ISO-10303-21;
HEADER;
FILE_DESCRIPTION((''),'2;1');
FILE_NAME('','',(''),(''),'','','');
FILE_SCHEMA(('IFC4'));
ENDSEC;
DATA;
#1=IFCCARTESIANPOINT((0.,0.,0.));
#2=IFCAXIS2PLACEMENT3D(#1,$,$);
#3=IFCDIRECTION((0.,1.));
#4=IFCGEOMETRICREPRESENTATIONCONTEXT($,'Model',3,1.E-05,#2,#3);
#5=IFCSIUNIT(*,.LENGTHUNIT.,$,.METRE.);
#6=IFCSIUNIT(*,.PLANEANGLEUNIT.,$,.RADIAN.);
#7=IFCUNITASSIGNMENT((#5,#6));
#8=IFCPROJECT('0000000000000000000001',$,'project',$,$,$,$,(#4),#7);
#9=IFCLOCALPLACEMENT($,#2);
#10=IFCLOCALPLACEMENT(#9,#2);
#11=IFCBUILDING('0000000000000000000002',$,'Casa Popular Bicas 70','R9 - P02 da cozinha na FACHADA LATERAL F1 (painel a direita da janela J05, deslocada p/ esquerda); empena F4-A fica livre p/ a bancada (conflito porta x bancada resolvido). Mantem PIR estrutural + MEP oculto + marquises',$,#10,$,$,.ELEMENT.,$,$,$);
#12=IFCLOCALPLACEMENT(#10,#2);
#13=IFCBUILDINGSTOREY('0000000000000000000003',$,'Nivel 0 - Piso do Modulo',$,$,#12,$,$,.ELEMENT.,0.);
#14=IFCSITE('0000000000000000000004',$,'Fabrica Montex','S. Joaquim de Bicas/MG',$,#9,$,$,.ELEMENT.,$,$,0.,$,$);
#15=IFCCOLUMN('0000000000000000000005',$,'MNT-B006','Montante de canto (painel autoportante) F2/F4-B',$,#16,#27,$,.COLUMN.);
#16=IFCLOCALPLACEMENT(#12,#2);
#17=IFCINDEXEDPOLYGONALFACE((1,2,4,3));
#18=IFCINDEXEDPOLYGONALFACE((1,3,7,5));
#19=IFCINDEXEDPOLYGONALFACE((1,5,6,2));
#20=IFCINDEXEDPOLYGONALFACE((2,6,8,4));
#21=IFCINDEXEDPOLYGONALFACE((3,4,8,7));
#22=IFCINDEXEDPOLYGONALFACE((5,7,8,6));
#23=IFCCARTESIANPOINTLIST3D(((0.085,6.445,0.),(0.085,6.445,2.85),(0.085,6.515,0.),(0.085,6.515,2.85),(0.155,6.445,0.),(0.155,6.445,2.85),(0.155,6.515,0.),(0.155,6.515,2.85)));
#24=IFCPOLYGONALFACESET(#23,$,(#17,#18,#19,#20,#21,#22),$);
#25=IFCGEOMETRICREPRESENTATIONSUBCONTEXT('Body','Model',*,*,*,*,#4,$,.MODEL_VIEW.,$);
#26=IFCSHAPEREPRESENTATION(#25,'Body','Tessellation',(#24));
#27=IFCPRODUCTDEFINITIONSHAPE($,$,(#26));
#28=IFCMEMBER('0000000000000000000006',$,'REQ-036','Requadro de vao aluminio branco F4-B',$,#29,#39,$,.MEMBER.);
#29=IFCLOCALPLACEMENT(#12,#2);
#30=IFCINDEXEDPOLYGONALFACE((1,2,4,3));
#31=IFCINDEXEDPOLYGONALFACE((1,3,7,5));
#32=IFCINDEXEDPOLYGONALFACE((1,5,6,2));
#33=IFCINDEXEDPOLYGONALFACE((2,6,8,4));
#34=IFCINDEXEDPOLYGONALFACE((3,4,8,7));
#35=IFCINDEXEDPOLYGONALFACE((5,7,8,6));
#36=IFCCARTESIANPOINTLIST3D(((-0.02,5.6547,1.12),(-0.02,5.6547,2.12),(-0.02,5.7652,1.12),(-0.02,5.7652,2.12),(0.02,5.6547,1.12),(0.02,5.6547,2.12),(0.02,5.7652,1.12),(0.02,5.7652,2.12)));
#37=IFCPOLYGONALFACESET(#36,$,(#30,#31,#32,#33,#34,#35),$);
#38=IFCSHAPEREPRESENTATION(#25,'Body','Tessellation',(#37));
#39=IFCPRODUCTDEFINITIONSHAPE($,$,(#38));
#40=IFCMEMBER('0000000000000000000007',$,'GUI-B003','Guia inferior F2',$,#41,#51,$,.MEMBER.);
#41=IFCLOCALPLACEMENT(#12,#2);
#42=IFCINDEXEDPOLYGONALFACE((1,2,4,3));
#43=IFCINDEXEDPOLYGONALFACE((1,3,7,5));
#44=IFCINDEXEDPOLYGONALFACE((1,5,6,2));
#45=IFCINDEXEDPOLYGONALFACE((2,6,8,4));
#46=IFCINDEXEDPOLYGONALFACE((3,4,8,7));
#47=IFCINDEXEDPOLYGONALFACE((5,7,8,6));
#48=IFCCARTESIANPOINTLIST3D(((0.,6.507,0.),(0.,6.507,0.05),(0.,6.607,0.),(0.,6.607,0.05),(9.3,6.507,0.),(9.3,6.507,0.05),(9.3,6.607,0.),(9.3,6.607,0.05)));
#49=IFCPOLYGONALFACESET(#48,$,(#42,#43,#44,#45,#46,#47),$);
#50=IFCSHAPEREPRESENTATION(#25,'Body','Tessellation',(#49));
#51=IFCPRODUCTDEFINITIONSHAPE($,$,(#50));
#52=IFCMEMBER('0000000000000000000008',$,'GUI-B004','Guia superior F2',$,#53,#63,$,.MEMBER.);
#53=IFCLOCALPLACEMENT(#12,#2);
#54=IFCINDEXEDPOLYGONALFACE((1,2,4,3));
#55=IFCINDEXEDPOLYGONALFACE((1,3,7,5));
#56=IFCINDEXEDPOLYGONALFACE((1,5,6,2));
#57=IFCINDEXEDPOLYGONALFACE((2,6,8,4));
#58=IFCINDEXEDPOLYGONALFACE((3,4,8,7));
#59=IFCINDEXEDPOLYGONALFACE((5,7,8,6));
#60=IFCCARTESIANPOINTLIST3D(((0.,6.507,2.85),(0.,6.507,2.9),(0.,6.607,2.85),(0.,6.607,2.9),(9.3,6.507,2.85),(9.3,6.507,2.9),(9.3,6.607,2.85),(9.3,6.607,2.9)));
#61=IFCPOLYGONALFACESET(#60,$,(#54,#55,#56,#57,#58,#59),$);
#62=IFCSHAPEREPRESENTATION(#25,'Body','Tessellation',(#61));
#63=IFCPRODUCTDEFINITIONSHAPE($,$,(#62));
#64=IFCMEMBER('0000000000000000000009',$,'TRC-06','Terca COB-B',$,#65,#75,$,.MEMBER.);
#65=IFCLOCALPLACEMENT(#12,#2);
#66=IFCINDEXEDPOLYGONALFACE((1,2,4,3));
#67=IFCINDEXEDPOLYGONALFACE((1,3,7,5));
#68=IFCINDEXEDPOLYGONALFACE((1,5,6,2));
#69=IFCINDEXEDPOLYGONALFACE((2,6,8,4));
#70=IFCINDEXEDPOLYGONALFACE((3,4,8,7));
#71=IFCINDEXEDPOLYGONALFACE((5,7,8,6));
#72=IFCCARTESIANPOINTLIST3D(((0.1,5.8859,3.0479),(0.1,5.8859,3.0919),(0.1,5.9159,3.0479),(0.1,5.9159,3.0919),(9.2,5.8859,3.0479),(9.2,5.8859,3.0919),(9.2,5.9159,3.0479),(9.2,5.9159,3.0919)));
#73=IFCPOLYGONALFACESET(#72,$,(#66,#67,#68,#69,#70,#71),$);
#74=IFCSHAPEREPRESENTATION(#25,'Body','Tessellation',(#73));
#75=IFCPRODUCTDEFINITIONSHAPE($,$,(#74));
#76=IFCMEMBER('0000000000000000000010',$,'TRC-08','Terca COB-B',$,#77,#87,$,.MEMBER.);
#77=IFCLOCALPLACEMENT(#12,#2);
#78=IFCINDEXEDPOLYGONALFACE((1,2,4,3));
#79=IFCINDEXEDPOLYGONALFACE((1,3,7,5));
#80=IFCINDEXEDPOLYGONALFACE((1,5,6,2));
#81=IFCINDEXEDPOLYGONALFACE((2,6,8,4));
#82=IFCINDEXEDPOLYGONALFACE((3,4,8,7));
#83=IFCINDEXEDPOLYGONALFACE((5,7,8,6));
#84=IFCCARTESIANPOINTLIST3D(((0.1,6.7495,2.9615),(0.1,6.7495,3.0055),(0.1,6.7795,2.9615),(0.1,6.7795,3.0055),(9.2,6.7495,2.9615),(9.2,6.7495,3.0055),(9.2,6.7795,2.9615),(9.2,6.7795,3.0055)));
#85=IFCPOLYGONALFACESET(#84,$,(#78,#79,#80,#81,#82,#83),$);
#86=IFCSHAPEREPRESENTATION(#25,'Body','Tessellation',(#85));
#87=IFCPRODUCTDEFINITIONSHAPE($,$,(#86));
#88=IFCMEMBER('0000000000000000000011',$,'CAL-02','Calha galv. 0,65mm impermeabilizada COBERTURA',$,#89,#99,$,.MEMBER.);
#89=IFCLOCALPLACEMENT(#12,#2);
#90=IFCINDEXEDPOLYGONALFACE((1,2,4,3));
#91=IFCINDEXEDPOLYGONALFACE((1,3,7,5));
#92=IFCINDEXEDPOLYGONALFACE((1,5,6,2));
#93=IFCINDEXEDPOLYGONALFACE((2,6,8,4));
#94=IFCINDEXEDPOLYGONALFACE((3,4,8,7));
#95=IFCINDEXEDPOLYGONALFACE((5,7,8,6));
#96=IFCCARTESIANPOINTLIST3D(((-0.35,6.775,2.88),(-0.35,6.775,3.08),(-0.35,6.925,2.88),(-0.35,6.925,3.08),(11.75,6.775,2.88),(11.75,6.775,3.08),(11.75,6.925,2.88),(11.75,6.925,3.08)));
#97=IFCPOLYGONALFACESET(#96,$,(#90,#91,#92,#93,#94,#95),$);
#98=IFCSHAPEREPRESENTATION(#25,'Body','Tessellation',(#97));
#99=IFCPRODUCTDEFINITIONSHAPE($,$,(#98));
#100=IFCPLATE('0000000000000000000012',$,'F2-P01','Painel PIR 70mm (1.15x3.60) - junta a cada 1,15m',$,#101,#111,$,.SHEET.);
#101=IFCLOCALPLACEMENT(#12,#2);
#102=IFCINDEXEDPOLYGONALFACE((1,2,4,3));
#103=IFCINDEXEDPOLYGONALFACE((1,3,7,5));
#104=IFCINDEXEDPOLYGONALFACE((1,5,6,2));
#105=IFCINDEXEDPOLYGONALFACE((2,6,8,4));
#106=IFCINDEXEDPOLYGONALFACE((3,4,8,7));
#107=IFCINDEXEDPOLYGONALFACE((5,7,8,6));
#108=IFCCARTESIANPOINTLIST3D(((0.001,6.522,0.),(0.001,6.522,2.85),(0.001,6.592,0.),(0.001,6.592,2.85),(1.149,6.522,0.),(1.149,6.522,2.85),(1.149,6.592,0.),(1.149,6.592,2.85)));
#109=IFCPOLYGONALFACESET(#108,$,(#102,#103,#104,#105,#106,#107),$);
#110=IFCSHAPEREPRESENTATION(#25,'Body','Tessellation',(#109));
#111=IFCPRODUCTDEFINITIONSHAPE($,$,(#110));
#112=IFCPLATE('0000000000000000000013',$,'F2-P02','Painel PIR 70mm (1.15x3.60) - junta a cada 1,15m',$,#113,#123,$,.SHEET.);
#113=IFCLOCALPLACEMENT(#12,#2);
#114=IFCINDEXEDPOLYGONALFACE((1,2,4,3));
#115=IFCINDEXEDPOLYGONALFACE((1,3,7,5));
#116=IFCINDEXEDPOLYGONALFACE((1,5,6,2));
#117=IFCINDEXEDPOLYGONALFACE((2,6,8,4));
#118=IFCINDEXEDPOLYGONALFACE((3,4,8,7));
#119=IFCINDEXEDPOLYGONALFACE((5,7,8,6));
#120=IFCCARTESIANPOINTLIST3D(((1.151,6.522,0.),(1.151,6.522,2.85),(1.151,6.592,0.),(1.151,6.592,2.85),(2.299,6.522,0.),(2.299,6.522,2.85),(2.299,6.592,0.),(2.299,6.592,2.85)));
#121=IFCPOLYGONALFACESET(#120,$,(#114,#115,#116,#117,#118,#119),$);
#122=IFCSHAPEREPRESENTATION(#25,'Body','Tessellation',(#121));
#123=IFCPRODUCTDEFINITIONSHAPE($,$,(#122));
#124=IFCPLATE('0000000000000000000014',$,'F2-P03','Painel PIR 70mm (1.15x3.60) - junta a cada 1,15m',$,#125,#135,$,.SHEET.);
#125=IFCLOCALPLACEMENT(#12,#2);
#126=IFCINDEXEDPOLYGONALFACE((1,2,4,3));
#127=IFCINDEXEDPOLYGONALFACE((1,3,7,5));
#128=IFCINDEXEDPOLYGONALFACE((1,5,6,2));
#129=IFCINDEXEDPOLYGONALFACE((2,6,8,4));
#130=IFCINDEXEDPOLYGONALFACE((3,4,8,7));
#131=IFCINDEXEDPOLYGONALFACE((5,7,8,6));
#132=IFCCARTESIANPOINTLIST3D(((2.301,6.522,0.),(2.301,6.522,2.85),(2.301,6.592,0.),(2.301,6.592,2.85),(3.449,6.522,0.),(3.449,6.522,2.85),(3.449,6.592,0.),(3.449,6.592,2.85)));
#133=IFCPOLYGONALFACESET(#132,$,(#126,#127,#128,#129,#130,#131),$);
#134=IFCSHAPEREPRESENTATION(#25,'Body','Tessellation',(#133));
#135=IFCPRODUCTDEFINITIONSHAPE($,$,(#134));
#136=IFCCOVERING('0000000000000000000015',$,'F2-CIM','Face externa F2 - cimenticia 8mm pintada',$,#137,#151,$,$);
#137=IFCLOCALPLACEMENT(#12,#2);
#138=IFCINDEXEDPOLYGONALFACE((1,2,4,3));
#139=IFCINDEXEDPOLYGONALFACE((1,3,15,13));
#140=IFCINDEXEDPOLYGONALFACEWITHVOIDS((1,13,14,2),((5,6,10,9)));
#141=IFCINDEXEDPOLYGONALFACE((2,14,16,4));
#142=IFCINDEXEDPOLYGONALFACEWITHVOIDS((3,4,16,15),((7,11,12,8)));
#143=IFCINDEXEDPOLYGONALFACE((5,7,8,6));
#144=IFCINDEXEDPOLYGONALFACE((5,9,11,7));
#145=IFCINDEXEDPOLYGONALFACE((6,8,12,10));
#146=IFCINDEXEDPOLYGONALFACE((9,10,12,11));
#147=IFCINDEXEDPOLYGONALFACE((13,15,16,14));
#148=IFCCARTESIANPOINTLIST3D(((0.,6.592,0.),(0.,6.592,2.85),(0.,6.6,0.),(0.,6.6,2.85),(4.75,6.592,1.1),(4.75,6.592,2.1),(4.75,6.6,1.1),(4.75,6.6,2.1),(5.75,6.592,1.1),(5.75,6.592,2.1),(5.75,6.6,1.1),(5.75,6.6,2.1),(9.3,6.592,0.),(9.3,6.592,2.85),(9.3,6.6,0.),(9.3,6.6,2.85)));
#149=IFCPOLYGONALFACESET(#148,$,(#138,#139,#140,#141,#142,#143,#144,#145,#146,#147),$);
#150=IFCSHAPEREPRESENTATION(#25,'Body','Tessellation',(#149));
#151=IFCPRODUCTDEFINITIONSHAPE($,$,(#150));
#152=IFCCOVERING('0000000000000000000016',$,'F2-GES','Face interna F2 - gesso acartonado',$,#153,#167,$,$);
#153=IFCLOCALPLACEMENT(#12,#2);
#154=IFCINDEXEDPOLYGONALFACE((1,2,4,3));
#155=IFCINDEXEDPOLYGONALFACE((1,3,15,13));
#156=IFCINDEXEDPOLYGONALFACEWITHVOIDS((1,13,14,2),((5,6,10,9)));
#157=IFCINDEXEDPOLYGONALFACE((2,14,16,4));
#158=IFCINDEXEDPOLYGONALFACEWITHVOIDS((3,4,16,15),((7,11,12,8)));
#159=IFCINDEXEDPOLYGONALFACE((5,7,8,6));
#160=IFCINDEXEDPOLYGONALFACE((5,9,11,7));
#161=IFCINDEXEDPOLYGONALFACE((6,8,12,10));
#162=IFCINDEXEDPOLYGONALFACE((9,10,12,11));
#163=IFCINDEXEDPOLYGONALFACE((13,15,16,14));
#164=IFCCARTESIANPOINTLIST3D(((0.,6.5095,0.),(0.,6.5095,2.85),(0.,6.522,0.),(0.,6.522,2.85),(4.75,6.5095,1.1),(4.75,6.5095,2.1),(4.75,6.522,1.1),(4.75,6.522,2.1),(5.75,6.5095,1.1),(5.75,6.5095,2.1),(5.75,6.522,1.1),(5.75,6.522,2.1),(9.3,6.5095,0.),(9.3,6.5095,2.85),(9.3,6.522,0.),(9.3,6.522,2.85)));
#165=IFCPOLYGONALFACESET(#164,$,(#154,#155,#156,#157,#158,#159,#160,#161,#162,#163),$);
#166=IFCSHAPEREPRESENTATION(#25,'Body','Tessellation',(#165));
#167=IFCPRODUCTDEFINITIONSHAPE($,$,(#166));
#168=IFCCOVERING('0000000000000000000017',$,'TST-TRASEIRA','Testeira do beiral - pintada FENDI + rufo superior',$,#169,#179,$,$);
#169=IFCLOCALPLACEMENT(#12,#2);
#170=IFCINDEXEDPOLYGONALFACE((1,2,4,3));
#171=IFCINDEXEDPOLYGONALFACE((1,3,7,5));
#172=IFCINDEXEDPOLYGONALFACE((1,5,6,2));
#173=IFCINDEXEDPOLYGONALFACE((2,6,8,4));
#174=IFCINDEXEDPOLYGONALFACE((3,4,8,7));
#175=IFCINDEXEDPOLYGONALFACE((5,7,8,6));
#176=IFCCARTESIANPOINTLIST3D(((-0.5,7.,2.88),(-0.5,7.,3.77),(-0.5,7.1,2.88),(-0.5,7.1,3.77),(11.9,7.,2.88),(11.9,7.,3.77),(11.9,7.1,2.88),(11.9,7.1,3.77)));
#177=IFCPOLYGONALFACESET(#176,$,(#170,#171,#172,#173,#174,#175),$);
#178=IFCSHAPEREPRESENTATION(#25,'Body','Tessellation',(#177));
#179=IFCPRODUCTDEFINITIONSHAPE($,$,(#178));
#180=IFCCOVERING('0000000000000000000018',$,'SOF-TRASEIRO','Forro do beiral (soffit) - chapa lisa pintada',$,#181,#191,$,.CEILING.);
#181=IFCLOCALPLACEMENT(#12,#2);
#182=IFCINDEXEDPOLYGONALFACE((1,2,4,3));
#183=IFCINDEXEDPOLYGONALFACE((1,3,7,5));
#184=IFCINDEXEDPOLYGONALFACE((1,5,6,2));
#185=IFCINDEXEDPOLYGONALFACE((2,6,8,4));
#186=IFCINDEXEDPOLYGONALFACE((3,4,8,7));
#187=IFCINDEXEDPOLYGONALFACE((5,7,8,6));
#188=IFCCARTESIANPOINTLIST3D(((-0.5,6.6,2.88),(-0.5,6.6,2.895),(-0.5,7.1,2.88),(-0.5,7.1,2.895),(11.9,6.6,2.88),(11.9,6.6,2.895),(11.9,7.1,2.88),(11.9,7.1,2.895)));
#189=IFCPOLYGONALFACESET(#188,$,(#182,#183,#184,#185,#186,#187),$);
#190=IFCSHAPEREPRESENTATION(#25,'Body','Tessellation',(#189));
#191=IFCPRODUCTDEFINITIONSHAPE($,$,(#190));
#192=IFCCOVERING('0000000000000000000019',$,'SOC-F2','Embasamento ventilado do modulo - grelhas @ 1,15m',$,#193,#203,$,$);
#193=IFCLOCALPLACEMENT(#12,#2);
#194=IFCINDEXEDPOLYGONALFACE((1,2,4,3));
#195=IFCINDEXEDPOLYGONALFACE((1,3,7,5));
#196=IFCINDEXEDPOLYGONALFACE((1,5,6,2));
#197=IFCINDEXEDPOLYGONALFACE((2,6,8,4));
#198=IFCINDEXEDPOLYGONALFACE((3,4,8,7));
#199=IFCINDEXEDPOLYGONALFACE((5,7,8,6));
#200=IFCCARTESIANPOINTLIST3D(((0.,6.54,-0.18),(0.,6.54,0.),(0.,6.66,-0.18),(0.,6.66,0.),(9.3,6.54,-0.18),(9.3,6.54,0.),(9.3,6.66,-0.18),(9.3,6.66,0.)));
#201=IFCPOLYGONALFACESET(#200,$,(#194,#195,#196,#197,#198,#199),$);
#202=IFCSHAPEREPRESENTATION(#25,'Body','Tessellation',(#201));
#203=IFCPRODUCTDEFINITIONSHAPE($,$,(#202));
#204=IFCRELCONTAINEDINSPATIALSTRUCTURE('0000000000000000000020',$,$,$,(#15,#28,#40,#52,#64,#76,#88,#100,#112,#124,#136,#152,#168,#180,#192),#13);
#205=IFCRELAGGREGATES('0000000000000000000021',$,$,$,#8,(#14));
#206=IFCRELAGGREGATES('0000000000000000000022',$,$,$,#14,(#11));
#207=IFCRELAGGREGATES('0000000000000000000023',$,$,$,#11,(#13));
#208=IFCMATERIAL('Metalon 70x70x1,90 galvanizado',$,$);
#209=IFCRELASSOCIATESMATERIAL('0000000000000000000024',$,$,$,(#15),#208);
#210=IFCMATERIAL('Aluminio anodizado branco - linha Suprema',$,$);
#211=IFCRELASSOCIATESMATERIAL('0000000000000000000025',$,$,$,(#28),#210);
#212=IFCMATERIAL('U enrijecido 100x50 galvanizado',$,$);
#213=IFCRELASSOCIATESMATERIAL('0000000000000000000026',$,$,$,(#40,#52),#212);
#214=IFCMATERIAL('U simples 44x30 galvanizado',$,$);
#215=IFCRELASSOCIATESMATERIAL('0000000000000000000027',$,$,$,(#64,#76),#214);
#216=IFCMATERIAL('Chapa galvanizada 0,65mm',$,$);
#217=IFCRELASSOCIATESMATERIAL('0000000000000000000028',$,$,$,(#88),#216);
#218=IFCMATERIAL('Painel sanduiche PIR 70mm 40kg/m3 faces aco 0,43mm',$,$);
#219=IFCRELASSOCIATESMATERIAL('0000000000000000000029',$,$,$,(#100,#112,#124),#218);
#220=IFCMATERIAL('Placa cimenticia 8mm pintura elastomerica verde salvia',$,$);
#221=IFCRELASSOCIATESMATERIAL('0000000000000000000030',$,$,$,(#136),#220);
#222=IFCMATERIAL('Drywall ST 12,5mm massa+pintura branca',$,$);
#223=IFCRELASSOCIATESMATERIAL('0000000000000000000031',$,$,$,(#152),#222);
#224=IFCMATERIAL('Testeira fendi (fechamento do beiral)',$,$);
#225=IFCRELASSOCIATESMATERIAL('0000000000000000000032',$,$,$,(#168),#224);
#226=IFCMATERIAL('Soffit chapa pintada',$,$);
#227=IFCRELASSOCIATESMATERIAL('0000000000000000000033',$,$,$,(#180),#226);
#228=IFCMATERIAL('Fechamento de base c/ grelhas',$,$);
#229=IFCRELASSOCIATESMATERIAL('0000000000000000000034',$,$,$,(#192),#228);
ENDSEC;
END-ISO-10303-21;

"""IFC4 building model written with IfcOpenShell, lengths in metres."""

from ifc_helpers import new_model, si_unit, direction, frame, frame_2d, origin, origin_2d, place, context, subcontext, project, spatial, rectangle, extrude, material, element, save


model = new_model("IFC4")

# Units and contexts
model_context = context("Model", 3, precision=1e-05, world=origin(), true_north=direction((0.0, 1.0)))
body_context = subcontext(model_context, "Body", "Model", "MODEL_VIEW")
ifc_project = project(units=[si_unit("LENGTHUNIT", "METRE"), si_unit("PLANEANGLEUNIT", "RADIAN")], contexts=[model_context])

# Site, building, storey
site_placement = place(None, origin())
site = spatial("IfcSite", under=ifc_project, at=site_placement, Name="Fabrica Montex", Description="S. Joaquim de Bicas/MG", CompositionType="ELEMENT", RefElevation=0.0)
building_placement = place(site_placement, origin())
building = spatial("IfcBuilding", under=site, at=building_placement, Name="Casa Popular Bicas 70", Description="R9 - P02 da cozinha na FACHADA LATERAL F1 (painel a direita da janela J05, deslocada p/ esquerda); empena F4-A fica livre p/ a bancada (conflito porta x bancada resolvido). Mantem PIR estrutural + MEP oculto + marquises", CompositionType="ELEMENT")
storey_placement = place(building_placement, origin())
storey = spatial("IfcBuildingStorey", under=building, at=storey_placement, Name="Nivel 0 - Piso do Modulo", CompositionType="ELEMENT", Elevation=0.0)

# Column
ifc_material_1 = material(Name="Metalon 70x70x1,90 galvanizado")
column_placement = place(storey_placement, frame((0.12, 6.48, 0.0)))
element("IfcColumn", 1, at=column_placement, inside=storey, material=ifc_material_1, Name="MNT-B006", Description="Montante de canto (painel autoportante) F2/F4-B", PredefinedType="COLUMN", context=body_context, shape_type="SweptSolid", body=[
    extrude(rectangle(XDim=0.07, YDim=0.07, at=origin_2d()), origin(), (0.0, 0.0, 1.0), 2.85),
])

# Members
ifc_material_2 = material(Name="Aluminio anodizado branco - linha Suprema")
member_1_placement = place(storey_placement, frame((0.0, 5.71, 1.12), z_axis=(0.0, 0.0, 1.0), x_axis=(1.0, 0.0, 0.0)))
element("IfcMember", 2, at=member_1_placement, inside=storey, material=ifc_material_2, Name="REQ-036", Description="Requadro de vao aluminio branco F4-B", PredefinedType="MEMBER", context=body_context, shape_type="SweptSolid", body=[
    extrude(rectangle(XDim=0.04, YDim=0.1105, at=origin_2d()), origin(), (0.0, 0.0, 1.0), 1.0),
])
ifc_material_3 = material(Name="U enrijecido 100x50 galvanizado")
for number, where, z_axis, x_axis, name, description in (
    (3, (0.0, 6.557, 0.025), (1.0, 0.0, 0.0), (0.0, 0.0, 1.0), "GUI-B003", "Guia inferior F2"),
    (4, (0.0, 6.557, 2.875), (1.0, 0.0, 0.0), (0.0, 0.0, 1.0), "GUI-B004", "Guia superior F2"),
):
    element("IfcMember", number, at=place(storey_placement, frame(where, z_axis=z_axis, x_axis=x_axis)), inside=storey, material=ifc_material_3, Name=name, Description=description, PredefinedType="MEMBER", context=body_context, shape_type="SweptSolid", body=[
        extrude(rectangle(XDim=0.05, YDim=0.1, at=origin_2d()), origin(), (0.0, 0.0, 1.0), 9.3),
    ])
ifc_material_4 = material(Name="U simples 44x30 galvanizado")
for number, where, z_axis, x_axis, name in (
    (5, (0.1, 5.9009, 3.0699), (1.0, 0.0, 0.0), (0.0, 0.0, 1.0), "TRC-06"),
    (6, (0.1, 6.7645, 2.9835), (1.0, 0.0, 0.0), (0.0, 0.0, 1.0), "TRC-08"),
):
    element("IfcMember", number, at=place(storey_placement, frame(where, z_axis=z_axis, x_axis=x_axis)), inside=storey, material=ifc_material_4, Name=name, Description="Terca COB-B", PredefinedType="MEMBER", context=body_context, shape_type="SweptSolid", body=[
        extrude(rectangle(XDim=0.044, YDim=0.03, at=origin_2d()), origin(), (0.0, 0.0, 1.0), 9.1),
    ])
ifc_material_5 = material(Name="Chapa galvanizada 0,65mm")
member_2_placement = place(storey_placement, frame((-0.35, 6.85, 2.98), z_axis=(1.0, 0.0, 0.0), x_axis=(0.0, 0.0, 1.0)))
element("IfcMember", 7, at=member_2_placement, inside=storey, material=ifc_material_5, Name="CAL-02", Description="Calha galv. 0,65mm impermeabilizada COBERTURA", PredefinedType="MEMBER", context=body_context, shape_type="SweptSolid", body=[
    extrude(rectangle(XDim=0.2, YDim=0.15, at=origin_2d()), origin(), (0.0, 0.0, 1.0), 12.1),
])

# Plates
ifc_material_6 = material(Name="Painel sanduiche PIR 70mm 40kg/m3 faces aco 0,43mm")
for number, where, x_axis, name in (
    (8, (0.001, 6.557, 0.0), (1.0, 0.0, 0.0), "F2-P01"),
    (9, (1.151, 6.557, 0.0), (1.0, 0.0, 0.0), "F2-P02"),
    (10, (2.301, 6.557, 0.0), (1.0, 0.0, 0.0), "F2-P03"),
):
    element("IfcPlate", number, at=place(storey_placement, frame(where, x_axis=x_axis)), inside=storey, material=ifc_material_6, Name=name, Description="Painel PIR 70mm (1.15x3.60) - junta a cada 1,15m", PredefinedType="SHEET", context=body_context, shape_type="SweptSolid", body=[
        extrude(rectangle(XDim=1.148, YDim=0.07, at=frame_2d((0.574, 0.0))), origin(), (0.0, 0.0, 1.0), 2.85),
    ])

# Coverings, openings
ifc_material_7 = material(Name="Placa cimenticia 8mm pintura elastomerica verde salvia")
covering_1_placement = place(storey_placement, frame((0.0, 6.596, 0.0), x_axis=(1.0, 0.0, 0.0)))
covering_1 = element("IfcCovering", 11, at=covering_1_placement, inside=storey, material=ifc_material_7, Name="F2-CIM", Description="Face externa F2 - cimenticia 8mm pintada", context=body_context, shape_type="SweptSolid", body=[
    extrude(rectangle(XDim=9.3, YDim=0.008, at=frame_2d((4.65, 0.0))), origin(), (0.0, 0.0, 1.0), 2.85),
])
opening_1_placement = place(storey_placement, frame((5.25, 6.596, 1.1)))
element("IfcOpeningElement", 12, at=opening_1_placement, cuts=covering_1, PredefinedType="OPENING", context=body_context, shape_type="SweptSolid", body=[
    extrude(rectangle(XDim=1.0, YDim=0.038, at=origin_2d()), origin(), (0.0, 0.0, 1.0), 1.0),
])
ifc_material_8 = material(Name="Drywall ST 12,5mm massa+pintura branca")
covering_2_placement = place(storey_placement, frame((0.0, 6.5157, 0.0), x_axis=(1.0, 0.0, 0.0)))
covering_2 = element("IfcCovering", 13, at=covering_2_placement, inside=storey, material=ifc_material_8, Name="F2-GES", Description="Face interna F2 - gesso acartonado", context=body_context, shape_type="SweptSolid", body=[
    extrude(rectangle(XDim=9.3, YDim=0.0125, at=frame_2d((4.65, 0.0))), origin(), (0.0, 0.0, 1.0), 2.85),
])
opening_2_placement = place(storey_placement, frame((5.25, 6.5157, 1.1)))
element("IfcOpeningElement", 14, at=opening_2_placement, cuts=covering_2, PredefinedType="OPENING", context=body_context, shape_type="SweptSolid", body=[
    extrude(rectangle(XDim=1.0, YDim=0.0425, at=origin_2d()), origin(), (0.0, 0.0, 1.0), 1.0),
])

# Coverings
ifc_material_9 = material(Name="Testeira fendi (fechamento do beiral)")
covering_3_placement = place(storey_placement, frame((-0.5, 7.05, 2.88), x_axis=(1.0, 0.0, 0.0)))
element("IfcCovering", 15, at=covering_3_placement, inside=storey, material=ifc_material_9, Name="TST-TRASEIRA", Description="Testeira do beiral - pintada FENDI + rufo superior", context=body_context, shape_type="SweptSolid", body=[
    extrude(rectangle(XDim=12.4, YDim=0.1, at=frame_2d((6.2, 0.0))), origin(), (0.0, 0.0, 1.0), 0.89),
])
ifc_material_10 = material(Name="Soffit chapa pintada")
covering_4_placement = place(storey_placement, frame((-0.5, 6.6, 2.88)))
element("IfcCovering", 16, at=covering_4_placement, inside=storey, material=ifc_material_10, Name="SOF-TRASEIRO", Description="Forro do beiral (soffit) - chapa lisa pintada", PredefinedType="CEILING", context=body_context, shape_type="SweptSolid", body=[
    extrude(rectangle(XDim=12.4, YDim=0.5, at=frame_2d((6.2, 0.25))), origin(), (0.0, 0.0, 1.0), 0.015),
])
ifc_material_11 = material(Name="Fechamento de base c/ grelhas")
covering_5_placement = place(storey_placement, frame((0.0, 6.6, -0.18), x_axis=(1.0, 0.0, 0.0)))
element("IfcCovering", 17, at=covering_5_placement, inside=storey, material=ifc_material_11, Name="SOC-F2", Description="Embasamento ventilado do modulo - grelhas @ 1,15m", context=body_context, shape_type="SweptSolid", body=[
    extrude(rectangle(XDim=9.3, YDim=0.12, at=frame_2d((4.65, 0.0))), origin(), (0.0, 0.0, 1.0), 0.18),
])

save(model, "model.ifc")
